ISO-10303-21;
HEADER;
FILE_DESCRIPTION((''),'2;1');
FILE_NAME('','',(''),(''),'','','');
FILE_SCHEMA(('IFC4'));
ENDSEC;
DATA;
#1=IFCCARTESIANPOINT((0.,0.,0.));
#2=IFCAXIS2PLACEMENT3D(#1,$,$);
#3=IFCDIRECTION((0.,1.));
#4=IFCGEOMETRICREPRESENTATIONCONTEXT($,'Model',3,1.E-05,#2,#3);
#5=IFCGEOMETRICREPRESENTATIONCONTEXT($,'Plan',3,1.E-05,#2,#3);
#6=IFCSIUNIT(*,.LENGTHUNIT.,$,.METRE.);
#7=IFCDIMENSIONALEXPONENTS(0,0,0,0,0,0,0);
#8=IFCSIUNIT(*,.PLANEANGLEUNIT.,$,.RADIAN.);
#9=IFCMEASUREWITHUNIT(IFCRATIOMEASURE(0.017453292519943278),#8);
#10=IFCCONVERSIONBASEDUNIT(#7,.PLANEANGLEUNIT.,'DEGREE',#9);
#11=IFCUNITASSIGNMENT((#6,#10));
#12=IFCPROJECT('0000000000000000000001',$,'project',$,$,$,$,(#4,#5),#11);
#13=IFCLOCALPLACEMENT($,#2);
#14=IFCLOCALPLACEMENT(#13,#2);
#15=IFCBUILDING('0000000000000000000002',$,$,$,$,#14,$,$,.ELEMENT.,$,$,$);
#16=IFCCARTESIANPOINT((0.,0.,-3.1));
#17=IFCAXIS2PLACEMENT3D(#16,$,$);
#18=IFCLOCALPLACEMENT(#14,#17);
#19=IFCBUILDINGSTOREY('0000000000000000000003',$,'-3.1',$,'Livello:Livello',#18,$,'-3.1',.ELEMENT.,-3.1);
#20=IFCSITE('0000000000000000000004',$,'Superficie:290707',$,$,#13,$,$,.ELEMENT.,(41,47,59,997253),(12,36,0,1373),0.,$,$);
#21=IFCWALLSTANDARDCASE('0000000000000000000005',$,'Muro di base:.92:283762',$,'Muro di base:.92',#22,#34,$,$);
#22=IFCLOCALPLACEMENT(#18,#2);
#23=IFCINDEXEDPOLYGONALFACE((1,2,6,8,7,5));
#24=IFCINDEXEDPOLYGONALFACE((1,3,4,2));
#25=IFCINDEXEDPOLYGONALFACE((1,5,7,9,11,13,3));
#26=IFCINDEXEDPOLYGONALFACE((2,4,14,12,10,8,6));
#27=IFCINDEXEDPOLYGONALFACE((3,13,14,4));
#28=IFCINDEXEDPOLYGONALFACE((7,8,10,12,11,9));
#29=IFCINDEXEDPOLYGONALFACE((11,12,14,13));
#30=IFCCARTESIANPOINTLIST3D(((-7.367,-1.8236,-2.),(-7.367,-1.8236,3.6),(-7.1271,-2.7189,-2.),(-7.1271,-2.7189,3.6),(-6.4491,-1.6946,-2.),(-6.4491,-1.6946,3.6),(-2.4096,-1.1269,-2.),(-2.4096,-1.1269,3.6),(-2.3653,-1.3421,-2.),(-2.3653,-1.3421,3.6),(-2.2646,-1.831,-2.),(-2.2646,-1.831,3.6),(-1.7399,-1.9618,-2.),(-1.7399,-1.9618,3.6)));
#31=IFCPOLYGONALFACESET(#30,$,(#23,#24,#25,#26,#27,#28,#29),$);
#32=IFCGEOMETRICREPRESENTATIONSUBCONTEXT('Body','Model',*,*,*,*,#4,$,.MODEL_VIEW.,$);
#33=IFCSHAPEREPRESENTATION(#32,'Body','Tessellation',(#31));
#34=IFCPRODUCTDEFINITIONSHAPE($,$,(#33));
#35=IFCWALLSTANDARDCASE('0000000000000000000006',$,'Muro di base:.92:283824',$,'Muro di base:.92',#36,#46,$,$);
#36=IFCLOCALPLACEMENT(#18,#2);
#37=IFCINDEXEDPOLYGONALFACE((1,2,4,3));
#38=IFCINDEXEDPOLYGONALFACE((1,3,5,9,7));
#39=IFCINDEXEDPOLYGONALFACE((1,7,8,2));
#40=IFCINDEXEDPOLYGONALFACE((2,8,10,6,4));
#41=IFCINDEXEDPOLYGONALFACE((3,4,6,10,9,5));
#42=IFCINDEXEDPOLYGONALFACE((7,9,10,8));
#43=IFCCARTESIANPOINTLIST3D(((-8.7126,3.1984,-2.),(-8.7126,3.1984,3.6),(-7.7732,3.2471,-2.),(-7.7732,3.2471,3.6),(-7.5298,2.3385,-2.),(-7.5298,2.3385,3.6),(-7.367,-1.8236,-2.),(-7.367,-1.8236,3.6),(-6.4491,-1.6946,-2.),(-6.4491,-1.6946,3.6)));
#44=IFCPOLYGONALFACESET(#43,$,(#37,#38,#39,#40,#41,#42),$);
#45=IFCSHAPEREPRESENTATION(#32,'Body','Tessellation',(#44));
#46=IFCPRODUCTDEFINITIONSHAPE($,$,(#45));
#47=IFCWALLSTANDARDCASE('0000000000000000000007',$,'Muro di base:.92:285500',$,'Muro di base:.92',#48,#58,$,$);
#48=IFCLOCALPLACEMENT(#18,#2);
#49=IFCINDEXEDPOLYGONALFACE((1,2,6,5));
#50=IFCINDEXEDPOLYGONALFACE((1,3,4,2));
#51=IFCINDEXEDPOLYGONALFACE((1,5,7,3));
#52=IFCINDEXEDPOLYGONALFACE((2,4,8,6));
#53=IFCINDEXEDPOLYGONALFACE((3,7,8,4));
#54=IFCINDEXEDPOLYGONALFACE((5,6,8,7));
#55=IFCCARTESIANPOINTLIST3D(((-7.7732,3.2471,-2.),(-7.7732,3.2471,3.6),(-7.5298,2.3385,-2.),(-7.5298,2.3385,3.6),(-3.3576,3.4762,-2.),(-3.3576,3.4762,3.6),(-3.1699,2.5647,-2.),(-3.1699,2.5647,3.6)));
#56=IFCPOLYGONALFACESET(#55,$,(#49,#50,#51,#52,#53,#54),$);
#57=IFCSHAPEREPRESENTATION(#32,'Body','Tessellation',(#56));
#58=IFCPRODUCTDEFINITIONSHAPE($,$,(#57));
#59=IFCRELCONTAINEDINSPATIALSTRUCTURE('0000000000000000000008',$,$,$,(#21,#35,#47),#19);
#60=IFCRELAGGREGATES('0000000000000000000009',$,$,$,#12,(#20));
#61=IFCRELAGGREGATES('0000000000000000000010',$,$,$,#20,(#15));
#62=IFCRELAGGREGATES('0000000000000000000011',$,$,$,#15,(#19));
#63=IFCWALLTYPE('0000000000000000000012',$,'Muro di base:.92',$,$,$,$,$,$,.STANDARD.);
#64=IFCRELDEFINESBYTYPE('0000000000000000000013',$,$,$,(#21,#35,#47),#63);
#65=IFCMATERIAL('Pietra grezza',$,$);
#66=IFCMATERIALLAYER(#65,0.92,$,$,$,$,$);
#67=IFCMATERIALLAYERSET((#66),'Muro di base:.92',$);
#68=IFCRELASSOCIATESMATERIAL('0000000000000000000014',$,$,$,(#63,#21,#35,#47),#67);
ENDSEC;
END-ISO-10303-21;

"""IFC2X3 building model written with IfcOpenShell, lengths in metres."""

from ifc_helpers import new_model, entity, si_unit, converted_unit, direction, frame, origin, place, context, subcontext, project, spatial, polyline, outline, extrude, material, layer, layer_set, layer_usage, type_object, element, save


model = new_model("IFC2X3")

# Units and contexts
model_context = context("Model", 3, precision=1e-05, world=origin(), true_north=direction((0.0, 1.0)))
plan_context = context("Plan", 3, precision=1e-05, world=origin(), true_north=direction((0.0, 1.0)))
body_context = subcontext(model_context, "Body", "Model", "MODEL_VIEW")
ifc_project = project(units=[si_unit("LENGTHUNIT", "METRE"), converted_unit("PLANEANGLEUNIT", "DEGREE", entity("IfcRatioMeasure", 0.017453292519943278), si_unit("PLANEANGLEUNIT", "RADIAN"), dimensions=[0, 0, 0, 0, 0, 0, 0])], contexts=[model_context, plan_context])

# Site, building, storey
site_placement = place(None, origin())
site = spatial("IfcSite", under=ifc_project, at=site_placement, Name="Superficie:290707", CompositionType="ELEMENT", RefLatitude=(41, 47, 59, 997253), RefLongitude=(12, 36, 0, 1373), RefElevation=0.0)
building_placement = place(site_placement, origin())
building = spatial("IfcBuilding", under=site, at=building_placement, CompositionType="ELEMENT")
storey_placement = place(building_placement, frame((0.0, 0.0, -3.1)))
storey = spatial("IfcBuildingStorey", under=building, at=storey_placement, Name="-3.1", ObjectType="Livello:Livello", LongName="-3.1", CompositionType="ELEMENT", Elevation=-3.1)

# Walls
ifc_material_1 = material(Name="Pietra grezza")
ifc_layer_1 = layer(ifc_material_1, 0.92)
ifc_layer_set_1 = layer_set([ifc_layer_1], Name="Muro di base:.92")
wall_type_1 = type_object("IfcWallType", Name="Muro di base:.92", PredefinedType="STANDARD", material=ifc_layer_set_1)
ifc_layer_usage_1 = layer_usage(ifc_layer_set_1, "AXIS2", "NEGATIVE", 0.46)
wall_1_placement = place(storey_placement, frame((-1.8039, -1.5063, -2.0), z_axis=(0.0, 0.0, 1.0), x_axis=(-0.990268, -0.139173, 0.0)))
element("IfcWallStandardCase", 1, at=wall_1_placement, inside=storey, type_object=wall_type_1, material=ifc_layer_usage_1, Name="Muro di base:.92:283762", ObjectType="Muro di base:.92", context=body_context, shape_type="SweptSolid", body=[
    extrude(outline(polyline([(5.5531, -0.46), (5.4401, 0.46), (0.0, 0.46), (0.5015, 0.2574), (0.5331, -0.2407), (0.5471, -0.46), (4.6262, -0.46), (5.5531, -0.46)])), origin(), (0.0, 0.0, 1.0), 5.6),
])
wall_2_placement = place(storey_placement, frame((-6.8934, -1.8137, -2.0), z_axis=(0.0, 0.0, 1.0), x_axis=(-0.258819, 0.965926, 0.0)))
element("IfcWallStandardCase", 2, at=wall_2_placement, inside=storey, type_object=wall_type_1, material=ifc_layer_usage_1, Name="Muro di base:.92:283824", ObjectType="Muro di base:.92", context=body_context, shape_type="SweptSolid", body=[
    extrude(outline(polyline([(5.1161, -0.46), (5.3121, 0.46), (0.113, 0.46), (0.0, -0.46), (4.1754, -0.46), (5.1161, -0.46)])), origin(), (0.0, 0.0, 1.0), 5.6),
])
wall_3_placement = place(storey_placement, frame((-7.7494, 2.7877, -2.0), z_axis=(0.0, 0.0, 1.0), x_axis=(0.998657, 0.051804, 0.0)))
element("IfcWallStandardCase", 3, at=wall_3_placement, inside=storey, type_object=wall_type_1, material=ifc_layer_usage_1, Name="Muro di base:.92:285500", ObjectType="Muro di base:.92", context=body_context, shape_type="SweptSolid", body=[
    extrude(outline(polyline([(4.5618, -0.46), (4.4216, 0.46), (0.0, 0.46), (0.1961, -0.46), (4.5618, -0.46)])), origin(), (0.0, 0.0, 1.0), 5.6),
])

save(model, "model.ifc")
